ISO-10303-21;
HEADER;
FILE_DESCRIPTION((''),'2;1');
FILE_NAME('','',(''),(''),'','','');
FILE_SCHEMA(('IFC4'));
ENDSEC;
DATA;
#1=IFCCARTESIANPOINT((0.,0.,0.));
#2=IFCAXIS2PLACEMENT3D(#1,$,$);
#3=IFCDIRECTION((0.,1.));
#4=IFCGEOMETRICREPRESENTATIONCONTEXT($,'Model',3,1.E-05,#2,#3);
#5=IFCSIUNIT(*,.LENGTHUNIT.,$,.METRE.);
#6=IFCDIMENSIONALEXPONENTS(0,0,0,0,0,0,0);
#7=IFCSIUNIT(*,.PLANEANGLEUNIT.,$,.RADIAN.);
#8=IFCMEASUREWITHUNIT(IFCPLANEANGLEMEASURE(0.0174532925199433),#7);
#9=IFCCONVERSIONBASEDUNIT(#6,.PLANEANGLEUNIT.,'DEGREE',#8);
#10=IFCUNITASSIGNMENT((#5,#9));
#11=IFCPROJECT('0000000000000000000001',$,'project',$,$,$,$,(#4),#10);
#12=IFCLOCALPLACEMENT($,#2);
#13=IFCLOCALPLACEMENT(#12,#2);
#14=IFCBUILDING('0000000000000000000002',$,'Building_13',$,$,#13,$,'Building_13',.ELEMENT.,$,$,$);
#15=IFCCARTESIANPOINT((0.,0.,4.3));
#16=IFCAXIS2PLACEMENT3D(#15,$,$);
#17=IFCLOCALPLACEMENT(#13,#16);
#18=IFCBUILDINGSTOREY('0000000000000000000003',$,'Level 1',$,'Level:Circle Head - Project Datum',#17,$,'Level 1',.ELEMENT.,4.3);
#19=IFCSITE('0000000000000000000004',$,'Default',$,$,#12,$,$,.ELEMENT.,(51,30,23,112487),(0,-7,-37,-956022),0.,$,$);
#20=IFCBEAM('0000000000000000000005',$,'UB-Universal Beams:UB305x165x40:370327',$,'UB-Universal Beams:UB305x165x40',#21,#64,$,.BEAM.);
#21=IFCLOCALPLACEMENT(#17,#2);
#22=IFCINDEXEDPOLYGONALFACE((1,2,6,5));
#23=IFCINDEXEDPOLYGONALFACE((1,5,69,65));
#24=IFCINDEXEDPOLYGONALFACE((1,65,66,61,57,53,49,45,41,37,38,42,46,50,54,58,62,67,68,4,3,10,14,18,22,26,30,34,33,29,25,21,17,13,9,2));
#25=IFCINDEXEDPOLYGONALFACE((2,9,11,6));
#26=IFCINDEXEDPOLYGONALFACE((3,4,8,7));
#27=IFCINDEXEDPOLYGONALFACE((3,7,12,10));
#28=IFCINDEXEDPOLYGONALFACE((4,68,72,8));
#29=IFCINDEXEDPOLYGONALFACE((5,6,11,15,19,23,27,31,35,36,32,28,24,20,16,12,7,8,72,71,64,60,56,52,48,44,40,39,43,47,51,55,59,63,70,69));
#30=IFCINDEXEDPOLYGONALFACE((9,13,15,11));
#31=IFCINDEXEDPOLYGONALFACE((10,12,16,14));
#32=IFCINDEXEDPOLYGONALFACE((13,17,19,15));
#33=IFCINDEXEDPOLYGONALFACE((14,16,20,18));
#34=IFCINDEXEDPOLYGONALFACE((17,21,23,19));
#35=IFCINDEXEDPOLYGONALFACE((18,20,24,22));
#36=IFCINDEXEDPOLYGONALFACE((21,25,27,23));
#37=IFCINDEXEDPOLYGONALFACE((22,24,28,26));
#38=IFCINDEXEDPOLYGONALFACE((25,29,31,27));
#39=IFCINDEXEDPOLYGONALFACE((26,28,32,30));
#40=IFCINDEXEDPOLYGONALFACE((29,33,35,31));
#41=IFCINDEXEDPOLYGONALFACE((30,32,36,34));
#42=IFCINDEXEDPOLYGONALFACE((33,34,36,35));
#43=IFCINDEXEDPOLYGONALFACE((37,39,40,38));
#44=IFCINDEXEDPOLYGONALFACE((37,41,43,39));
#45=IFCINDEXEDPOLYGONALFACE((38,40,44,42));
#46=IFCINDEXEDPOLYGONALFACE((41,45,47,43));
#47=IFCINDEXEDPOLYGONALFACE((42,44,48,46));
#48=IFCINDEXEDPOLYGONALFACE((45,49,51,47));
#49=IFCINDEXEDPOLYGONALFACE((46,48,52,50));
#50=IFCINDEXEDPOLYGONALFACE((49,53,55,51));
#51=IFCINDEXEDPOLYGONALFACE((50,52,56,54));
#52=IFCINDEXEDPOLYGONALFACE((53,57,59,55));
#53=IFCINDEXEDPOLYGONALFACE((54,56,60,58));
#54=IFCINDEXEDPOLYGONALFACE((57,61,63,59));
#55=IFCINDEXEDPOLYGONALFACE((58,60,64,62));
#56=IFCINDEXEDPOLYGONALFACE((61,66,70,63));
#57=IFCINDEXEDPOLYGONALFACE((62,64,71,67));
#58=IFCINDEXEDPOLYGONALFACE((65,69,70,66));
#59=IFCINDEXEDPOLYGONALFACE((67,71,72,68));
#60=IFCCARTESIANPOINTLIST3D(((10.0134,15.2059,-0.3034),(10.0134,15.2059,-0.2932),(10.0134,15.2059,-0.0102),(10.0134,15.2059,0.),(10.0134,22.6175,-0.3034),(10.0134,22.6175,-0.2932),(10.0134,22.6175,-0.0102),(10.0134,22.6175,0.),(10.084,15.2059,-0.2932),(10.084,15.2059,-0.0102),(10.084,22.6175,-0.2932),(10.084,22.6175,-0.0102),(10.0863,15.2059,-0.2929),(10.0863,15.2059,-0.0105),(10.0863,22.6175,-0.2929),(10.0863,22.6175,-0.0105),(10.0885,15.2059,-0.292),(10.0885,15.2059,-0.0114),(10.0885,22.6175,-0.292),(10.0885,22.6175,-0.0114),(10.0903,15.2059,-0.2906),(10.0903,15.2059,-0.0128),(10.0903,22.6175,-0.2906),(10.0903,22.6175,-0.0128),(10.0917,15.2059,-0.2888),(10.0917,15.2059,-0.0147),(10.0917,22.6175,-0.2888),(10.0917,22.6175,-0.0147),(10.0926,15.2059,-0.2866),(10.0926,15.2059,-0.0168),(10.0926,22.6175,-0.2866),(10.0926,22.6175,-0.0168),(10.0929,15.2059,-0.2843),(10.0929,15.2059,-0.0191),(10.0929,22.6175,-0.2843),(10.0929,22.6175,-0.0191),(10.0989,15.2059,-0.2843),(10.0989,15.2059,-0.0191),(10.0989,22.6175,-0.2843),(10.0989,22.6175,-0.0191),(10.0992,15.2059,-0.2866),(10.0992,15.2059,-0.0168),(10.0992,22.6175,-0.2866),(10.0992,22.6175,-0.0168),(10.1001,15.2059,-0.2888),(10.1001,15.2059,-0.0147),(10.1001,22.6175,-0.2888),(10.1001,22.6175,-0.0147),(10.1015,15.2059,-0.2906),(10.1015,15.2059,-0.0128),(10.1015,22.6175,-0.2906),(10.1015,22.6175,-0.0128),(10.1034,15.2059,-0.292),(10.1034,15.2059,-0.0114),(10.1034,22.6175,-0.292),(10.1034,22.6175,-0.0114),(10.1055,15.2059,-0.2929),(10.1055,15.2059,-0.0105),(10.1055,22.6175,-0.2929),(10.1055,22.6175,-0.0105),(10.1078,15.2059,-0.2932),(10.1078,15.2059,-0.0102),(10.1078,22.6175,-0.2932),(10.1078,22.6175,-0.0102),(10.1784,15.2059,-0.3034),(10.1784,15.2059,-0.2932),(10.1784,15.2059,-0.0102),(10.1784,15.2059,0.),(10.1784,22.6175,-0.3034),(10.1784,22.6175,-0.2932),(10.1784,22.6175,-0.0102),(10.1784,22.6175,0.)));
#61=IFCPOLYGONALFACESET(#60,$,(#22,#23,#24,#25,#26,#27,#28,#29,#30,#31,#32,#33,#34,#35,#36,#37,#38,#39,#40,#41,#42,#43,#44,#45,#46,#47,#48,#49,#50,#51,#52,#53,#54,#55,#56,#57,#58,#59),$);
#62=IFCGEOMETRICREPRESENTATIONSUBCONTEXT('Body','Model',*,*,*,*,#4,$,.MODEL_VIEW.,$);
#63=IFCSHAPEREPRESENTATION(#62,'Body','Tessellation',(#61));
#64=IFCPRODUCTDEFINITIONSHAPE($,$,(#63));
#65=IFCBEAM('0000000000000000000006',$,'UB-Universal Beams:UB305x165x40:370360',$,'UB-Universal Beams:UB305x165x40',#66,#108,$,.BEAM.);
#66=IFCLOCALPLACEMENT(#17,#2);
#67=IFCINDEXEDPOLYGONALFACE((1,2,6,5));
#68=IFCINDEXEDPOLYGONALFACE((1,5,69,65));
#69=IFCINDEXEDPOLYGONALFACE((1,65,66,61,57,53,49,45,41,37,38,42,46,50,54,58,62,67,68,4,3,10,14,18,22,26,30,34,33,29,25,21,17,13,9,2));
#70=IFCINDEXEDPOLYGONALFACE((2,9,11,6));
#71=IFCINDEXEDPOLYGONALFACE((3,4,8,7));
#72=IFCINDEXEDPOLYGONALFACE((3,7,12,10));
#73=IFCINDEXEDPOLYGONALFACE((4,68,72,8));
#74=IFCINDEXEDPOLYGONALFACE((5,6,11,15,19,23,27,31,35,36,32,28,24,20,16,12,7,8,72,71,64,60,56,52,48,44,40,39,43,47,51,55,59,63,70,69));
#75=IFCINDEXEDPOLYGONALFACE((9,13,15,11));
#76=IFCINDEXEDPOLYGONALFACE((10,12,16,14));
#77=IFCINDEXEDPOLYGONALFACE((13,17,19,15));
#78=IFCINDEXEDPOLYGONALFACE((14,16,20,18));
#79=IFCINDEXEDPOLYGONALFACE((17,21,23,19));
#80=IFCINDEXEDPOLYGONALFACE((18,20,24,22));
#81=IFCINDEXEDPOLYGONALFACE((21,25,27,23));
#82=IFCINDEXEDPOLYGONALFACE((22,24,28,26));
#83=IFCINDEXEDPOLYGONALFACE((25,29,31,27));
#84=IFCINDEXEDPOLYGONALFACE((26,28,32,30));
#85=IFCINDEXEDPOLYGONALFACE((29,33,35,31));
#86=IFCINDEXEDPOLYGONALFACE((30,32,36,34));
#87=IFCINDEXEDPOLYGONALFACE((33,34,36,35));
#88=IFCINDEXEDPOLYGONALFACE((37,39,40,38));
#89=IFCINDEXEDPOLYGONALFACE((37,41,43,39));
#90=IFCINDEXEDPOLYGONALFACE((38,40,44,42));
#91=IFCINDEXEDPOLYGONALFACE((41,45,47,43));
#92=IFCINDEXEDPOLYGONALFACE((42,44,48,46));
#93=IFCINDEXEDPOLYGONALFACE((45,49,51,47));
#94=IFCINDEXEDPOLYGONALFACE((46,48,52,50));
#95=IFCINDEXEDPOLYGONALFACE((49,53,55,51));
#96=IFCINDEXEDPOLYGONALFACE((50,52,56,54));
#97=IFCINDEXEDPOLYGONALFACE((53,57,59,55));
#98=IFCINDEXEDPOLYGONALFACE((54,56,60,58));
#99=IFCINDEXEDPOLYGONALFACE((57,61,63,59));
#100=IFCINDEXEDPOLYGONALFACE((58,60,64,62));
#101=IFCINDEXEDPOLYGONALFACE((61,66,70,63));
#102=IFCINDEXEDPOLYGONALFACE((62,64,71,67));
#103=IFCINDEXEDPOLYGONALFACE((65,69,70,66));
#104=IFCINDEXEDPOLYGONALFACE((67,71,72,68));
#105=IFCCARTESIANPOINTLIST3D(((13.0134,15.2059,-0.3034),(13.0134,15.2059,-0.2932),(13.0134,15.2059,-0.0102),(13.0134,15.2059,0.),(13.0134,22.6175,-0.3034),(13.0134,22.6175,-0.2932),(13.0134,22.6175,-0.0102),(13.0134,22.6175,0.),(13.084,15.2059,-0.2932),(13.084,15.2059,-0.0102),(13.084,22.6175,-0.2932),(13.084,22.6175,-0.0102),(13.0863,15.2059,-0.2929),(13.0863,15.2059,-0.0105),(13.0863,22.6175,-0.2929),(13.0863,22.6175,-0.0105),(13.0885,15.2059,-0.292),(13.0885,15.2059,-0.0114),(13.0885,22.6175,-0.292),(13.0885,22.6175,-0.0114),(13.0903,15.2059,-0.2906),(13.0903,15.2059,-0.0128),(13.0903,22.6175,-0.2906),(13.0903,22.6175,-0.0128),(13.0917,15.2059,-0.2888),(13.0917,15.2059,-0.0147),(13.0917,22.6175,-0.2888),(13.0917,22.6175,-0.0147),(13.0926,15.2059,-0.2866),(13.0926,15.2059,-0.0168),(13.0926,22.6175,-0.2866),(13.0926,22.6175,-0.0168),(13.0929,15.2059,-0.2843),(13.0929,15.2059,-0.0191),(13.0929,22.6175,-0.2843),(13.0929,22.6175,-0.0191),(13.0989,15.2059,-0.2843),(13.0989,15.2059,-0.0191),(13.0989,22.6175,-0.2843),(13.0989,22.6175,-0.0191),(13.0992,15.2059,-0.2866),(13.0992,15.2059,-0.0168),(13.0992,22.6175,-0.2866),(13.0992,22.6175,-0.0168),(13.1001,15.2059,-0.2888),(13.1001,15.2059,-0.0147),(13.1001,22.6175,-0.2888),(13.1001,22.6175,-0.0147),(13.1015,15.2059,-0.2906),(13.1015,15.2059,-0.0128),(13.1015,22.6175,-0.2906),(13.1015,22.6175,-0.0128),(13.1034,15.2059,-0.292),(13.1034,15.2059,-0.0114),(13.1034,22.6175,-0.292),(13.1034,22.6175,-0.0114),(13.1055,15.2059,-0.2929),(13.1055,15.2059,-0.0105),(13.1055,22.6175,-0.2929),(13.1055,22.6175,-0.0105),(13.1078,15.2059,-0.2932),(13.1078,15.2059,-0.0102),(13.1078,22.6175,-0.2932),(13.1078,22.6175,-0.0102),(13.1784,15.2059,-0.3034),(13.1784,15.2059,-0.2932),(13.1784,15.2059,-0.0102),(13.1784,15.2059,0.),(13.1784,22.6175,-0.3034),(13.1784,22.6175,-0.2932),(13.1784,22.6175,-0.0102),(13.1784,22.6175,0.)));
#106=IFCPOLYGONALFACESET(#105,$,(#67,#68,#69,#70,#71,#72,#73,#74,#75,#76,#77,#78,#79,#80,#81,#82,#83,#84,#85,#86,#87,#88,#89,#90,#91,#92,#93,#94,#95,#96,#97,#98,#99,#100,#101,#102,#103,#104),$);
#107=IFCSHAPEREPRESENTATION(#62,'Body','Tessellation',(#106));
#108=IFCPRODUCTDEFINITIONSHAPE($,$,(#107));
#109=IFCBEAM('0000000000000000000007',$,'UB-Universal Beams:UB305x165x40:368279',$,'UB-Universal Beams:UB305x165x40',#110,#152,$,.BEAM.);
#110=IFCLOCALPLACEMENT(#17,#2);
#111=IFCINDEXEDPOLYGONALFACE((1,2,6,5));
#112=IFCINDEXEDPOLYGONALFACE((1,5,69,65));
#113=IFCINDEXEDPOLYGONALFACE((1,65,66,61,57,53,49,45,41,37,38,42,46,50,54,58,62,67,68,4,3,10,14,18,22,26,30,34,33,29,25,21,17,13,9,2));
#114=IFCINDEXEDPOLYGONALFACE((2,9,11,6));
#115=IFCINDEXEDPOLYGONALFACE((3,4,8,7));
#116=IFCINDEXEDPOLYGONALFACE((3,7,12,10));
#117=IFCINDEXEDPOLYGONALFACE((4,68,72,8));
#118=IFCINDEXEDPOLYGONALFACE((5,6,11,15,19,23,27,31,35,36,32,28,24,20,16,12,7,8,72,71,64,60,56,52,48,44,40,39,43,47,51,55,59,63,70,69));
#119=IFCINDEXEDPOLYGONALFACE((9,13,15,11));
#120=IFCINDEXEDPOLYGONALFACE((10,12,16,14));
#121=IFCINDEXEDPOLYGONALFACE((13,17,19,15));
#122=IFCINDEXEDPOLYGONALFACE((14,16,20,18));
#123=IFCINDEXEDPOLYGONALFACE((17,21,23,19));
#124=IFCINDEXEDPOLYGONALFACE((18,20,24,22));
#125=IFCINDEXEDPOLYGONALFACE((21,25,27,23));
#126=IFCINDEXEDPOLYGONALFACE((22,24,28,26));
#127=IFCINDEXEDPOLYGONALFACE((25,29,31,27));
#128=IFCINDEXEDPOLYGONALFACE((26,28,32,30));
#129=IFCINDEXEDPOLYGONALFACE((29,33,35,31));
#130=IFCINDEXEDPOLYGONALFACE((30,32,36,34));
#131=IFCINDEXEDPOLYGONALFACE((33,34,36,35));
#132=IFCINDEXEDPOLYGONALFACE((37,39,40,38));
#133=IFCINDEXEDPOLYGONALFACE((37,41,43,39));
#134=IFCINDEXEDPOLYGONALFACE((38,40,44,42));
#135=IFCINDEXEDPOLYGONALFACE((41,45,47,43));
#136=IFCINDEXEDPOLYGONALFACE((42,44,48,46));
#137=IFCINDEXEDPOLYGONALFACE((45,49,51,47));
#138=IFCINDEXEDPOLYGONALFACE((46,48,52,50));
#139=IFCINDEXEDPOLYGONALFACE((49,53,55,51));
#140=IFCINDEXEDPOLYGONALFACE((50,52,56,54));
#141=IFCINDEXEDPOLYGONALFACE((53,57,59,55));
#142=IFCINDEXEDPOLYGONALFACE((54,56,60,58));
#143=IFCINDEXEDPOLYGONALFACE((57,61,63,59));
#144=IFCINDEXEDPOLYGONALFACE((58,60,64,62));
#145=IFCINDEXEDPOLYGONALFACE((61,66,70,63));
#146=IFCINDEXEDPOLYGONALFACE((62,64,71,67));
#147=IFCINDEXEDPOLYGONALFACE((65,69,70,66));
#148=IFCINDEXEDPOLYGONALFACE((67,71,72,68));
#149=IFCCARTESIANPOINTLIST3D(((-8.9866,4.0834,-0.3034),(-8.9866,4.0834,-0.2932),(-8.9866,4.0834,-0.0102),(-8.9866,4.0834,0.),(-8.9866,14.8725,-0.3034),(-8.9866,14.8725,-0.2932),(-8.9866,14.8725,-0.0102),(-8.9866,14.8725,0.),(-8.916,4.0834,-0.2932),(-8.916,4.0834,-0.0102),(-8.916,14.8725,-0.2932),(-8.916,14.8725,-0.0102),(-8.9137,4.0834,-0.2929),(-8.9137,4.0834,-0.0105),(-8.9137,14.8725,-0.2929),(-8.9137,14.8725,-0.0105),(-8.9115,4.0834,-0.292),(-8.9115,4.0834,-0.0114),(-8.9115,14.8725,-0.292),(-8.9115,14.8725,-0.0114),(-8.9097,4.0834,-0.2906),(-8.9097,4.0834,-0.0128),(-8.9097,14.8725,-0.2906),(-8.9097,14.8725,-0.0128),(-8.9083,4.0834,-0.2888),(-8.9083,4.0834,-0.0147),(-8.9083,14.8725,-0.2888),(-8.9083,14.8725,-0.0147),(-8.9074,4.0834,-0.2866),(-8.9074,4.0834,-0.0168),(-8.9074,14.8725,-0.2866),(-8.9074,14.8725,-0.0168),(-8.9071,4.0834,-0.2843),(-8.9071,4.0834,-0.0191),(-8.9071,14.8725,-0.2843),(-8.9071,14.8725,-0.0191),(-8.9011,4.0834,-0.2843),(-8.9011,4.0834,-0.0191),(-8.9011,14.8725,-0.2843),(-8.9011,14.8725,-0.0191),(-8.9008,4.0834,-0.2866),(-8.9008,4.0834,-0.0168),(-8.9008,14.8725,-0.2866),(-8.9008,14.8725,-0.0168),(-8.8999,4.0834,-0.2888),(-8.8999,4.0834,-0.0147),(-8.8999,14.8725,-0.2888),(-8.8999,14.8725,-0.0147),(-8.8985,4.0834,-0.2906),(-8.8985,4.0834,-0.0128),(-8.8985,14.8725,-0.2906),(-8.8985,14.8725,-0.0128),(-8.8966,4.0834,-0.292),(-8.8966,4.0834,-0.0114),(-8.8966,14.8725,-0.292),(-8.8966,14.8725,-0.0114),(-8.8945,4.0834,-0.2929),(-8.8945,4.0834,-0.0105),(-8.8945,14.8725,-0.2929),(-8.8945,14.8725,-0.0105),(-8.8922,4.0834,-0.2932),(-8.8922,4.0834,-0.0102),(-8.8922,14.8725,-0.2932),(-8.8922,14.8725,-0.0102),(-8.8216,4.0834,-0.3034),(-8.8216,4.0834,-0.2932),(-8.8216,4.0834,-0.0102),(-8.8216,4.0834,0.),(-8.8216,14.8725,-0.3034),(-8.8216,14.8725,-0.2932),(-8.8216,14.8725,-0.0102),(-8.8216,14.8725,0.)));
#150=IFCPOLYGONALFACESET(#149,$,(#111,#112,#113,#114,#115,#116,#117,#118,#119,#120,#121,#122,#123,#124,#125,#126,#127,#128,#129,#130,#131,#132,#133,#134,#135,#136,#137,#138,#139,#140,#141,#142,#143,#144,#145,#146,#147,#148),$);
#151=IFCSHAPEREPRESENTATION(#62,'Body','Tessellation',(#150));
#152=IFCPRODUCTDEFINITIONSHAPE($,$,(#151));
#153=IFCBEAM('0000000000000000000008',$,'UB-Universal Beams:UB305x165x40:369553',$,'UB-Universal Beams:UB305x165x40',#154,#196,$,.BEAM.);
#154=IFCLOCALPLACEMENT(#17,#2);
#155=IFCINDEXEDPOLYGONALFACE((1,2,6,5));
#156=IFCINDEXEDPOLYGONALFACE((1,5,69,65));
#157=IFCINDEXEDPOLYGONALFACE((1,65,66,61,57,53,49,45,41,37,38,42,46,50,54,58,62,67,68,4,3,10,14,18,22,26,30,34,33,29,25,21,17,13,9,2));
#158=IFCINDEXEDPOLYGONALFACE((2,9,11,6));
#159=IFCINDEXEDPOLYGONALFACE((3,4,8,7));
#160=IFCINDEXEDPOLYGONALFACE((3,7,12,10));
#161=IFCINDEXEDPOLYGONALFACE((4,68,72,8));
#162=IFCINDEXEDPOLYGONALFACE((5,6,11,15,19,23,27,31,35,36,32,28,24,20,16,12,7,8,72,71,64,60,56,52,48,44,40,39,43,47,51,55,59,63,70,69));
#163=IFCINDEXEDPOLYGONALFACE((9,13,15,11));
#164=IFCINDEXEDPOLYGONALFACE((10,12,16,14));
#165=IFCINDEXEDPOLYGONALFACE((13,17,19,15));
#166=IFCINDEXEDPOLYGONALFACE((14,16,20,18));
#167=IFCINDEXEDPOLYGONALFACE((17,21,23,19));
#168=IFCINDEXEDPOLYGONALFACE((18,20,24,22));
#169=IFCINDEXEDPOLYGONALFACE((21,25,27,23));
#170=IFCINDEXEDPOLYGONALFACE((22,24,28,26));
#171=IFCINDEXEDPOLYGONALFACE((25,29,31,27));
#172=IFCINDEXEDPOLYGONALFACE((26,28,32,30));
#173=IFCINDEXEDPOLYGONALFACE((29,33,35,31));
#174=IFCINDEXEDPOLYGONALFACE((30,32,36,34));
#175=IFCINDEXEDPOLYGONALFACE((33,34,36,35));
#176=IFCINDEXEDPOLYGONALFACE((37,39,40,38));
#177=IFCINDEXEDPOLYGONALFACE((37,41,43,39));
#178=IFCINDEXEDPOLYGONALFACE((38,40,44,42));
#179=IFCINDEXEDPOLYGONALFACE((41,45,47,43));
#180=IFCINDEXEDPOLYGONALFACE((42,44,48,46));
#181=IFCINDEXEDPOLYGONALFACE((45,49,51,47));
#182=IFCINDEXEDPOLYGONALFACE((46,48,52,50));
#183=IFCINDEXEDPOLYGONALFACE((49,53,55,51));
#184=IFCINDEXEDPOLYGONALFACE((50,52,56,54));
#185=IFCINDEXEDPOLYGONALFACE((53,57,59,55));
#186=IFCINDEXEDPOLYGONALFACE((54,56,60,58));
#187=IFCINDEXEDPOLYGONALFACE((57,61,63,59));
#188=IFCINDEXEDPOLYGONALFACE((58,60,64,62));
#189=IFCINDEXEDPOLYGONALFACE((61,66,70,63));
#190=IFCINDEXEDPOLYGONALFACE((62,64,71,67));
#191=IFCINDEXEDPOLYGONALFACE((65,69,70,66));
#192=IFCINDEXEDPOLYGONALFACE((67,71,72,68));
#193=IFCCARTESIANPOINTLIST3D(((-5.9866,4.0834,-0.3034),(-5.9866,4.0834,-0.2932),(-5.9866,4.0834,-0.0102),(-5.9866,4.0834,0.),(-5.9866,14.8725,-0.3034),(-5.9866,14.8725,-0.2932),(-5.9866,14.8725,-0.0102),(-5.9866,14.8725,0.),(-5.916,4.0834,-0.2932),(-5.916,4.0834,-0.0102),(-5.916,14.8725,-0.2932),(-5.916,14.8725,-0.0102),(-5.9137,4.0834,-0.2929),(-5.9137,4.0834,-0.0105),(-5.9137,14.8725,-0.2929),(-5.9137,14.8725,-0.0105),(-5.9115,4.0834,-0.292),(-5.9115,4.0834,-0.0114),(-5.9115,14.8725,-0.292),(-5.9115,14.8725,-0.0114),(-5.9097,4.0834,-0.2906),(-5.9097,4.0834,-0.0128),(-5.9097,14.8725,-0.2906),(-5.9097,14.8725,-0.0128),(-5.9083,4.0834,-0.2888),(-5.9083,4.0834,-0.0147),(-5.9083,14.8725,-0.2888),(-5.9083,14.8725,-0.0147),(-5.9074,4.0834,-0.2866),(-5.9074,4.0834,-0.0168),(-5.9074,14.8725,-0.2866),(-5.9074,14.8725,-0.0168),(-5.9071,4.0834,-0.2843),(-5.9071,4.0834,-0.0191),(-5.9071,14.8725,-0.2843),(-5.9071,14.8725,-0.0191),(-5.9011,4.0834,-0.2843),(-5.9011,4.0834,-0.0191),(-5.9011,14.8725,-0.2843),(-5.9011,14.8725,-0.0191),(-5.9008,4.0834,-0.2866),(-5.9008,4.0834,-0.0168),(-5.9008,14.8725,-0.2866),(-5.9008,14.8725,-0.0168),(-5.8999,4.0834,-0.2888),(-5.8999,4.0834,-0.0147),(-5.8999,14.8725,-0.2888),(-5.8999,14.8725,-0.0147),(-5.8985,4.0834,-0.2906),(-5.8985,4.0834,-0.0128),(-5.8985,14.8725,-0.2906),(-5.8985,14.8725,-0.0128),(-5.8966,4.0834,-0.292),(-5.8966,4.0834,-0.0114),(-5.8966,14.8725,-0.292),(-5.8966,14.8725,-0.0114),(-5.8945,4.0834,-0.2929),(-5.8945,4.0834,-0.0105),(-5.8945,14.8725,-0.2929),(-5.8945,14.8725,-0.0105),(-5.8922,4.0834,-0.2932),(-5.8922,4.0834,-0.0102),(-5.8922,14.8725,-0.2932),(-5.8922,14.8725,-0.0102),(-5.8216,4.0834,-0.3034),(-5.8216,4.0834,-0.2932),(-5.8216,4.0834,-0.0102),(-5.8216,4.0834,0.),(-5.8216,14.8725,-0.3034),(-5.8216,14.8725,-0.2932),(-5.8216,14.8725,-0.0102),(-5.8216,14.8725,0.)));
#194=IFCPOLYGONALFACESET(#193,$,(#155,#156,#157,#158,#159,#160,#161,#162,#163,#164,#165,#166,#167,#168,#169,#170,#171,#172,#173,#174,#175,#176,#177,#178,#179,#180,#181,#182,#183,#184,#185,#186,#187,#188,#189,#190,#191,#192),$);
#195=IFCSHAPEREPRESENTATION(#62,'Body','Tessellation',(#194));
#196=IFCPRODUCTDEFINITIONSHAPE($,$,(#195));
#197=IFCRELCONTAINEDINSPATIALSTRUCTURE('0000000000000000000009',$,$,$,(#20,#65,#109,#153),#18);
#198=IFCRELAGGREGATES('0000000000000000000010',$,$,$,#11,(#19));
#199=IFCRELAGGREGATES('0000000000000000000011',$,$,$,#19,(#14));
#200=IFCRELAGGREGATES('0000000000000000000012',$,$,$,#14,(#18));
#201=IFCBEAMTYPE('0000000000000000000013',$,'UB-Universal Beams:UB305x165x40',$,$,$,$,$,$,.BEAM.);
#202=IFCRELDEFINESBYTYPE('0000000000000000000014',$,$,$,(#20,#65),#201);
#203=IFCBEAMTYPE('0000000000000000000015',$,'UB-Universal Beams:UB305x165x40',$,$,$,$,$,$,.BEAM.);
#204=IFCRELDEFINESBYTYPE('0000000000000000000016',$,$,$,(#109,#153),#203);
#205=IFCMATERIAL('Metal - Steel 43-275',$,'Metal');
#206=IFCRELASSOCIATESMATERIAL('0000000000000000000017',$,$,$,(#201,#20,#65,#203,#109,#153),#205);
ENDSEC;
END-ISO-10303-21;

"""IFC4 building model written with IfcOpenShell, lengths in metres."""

from ifc_helpers import new_model, entity, si_unit, converted_unit, direction, frame, origin, place, context, subcontext, project, spatial, line, arc, indexed_curve, outline, extrude, source, transform, mapped, material, type_object, type_shapes, element, save


model = new_model("IFC4")

# Units and contexts
model_context = context("Model", 3, precision=1e-05, world=origin(), true_north=direction((0.0, 1.0)))
body_context = subcontext(model_context, "Body", "Model", "MODEL_VIEW")
ifc_project = project(units=[si_unit("LENGTHUNIT", "METRE"), converted_unit("PLANEANGLEUNIT", "DEGREE", entity("IfcPlaneAngleMeasure", 0.0174532925199433), si_unit("PLANEANGLEUNIT", "RADIAN"), dimensions=[0, 0, 0, 0, 0, 0, 0])], contexts=[model_context])

# Site, building, storey
site_placement = place(None, origin())
site = spatial("IfcSite", under=ifc_project, at=site_placement, Name="Default", CompositionType="ELEMENT", RefLatitude=(51, 30, 23, 112487), RefLongitude=(0, -7, -37, -956022), RefElevation=0.0)
building_placement = place(site_placement, origin())
building = spatial("IfcBuilding", under=site, at=building_placement, Name="Building_13", LongName="Building_13", CompositionType="ELEMENT")
storey_placement = place(building_placement, frame((0.0, 0.0, 4.3)))
storey = spatial("IfcBuildingStorey", under=building, at=storey_placement, Name="Level 1", ObjectType="Level:Circle Head - Project Datum", LongName="Level 1", CompositionType="ELEMENT", Elevation=4.3)

# Beams
ifc_material_1 = material(Name="Metal - Steel 43-275", Category="Metal")
beam_type_1 = type_object("IfcBeamType", Name="UB-Universal Beams:UB305x165x40", PredefinedType="BEAM", material=ifc_material_1)
shared_shape_1 = source(origin(), body_context, "Body", "SweptSolid", [
    extrude(outline(indexed_curve([(-0.0825, -0.1415), (-0.0825, -0.1517), (0.0825, -0.1517), (0.0825, -0.1415), (0.0119, -0.1415), (0.0056, -0.1389), (0.003, -0.1326), (0.003, 0.1326), (0.0056, 0.1389), (0.0119, 0.1415), (0.0825, 0.1415), (0.0825, 0.1517), (-0.0825, 0.1517), (-0.0825, 0.1415), (-0.0119, 0.1415), (-0.0056, 0.1389), (-0.003, 0.1326), (-0.003, -0.1326), (-0.0056, -0.1389), (-0.0119, -0.1415)], segments=[line(1, 2, 3, 4, 5), arc(5, 6, 7), line(7, 8), arc(8, 9, 10), line(10, 11, 12, 13, 14, 15), arc(15, 16, 17), line(17, 18), arc(18, 19, 20), line(20, 1)], self_intersect=False)), frame((-3.7058, 0.0, 0.0), z_axis=(-1.0, 0.0, 0.0), x_axis=(0.0, -1.0, 0.0)), (0.0, 0.0, -1.0), 7.4116),
])
type_shapes(beam_type_1, [shared_shape_1])
for number, where, z_axis, x_axis, name in (
    (1, (10.0959, 18.9117, -0.1517), (0.0, 0.0, 1.0), (0.0, -1.0, 0.0), "UB-Universal Beams:UB305x165x40:370327"),
    (2, (13.0959, 18.9117, -0.1517), (0.0, 0.0, 1.0), (0.0, -1.0, 0.0), "UB-Universal Beams:UB305x165x40:370360"),
):
    element("IfcBeam", number, at=place(storey_placement, frame(where, z_axis=z_axis, x_axis=x_axis)), inside=storey, type_object=beam_type_1, material=ifc_material_1, Name=name, ObjectType="UB-Universal Beams:UB305x165x40", PredefinedType="BEAM", context=body_context, shape_type="MappedRepresentation", body=[
        mapped(shared_shape_1, transform((0.0, 0.0, 0.0), scale=1.0)),
    ])
beam_type_2 = type_object("IfcBeamType", Name="UB-Universal Beams:UB305x165x40", PredefinedType="BEAM", material=ifc_material_1)
shared_shape_2 = source(origin(), body_context, "Body", "SweptSolid", [
    extrude(outline(indexed_curve([(-0.0825, -0.1415), (-0.0825, -0.1517), (0.0825, -0.1517), (0.0825, -0.1415), (0.0119, -0.1415), (0.0056, -0.1389), (0.003, -0.1326), (0.003, 0.1326), (0.0056, 0.1389), (0.0119, 0.1415), (0.0825, 0.1415), (0.0825, 0.1517), (-0.0825, 0.1517), (-0.0825, 0.1415), (-0.0119, 0.1415), (-0.0056, 0.1389), (-0.003, 0.1326), (-0.003, -0.1326), (-0.0056, -0.1389), (-0.0119, -0.1415)], segments=[line(1, 2, 3, 4, 5), arc(5, 6, 7), line(7, 8), arc(8, 9, 10), line(10, 11, 12, 13, 14, 15), arc(15, 16, 17), line(17, 18), arc(18, 19, 20), line(20, 1)], self_intersect=False)), frame((-5.3945, 0.0, 0.0), z_axis=(-1.0, 0.0, 0.0), x_axis=(0.0, -1.0, 0.0)), (0.0, 0.0, -1.0), 10.7891),
])
type_shapes(beam_type_2, [shared_shape_2])
for number, where, z_axis, x_axis, name in (
    (3, (-8.9041, 9.4779, -0.1517), (0.0, 0.0, 1.0), (0.0, -1.0, 0.0), "UB-Universal Beams:UB305x165x40:368279"),
    (4, (-5.9041, 9.4779, -0.1517), (0.0, 0.0, 1.0), (0.0, -1.0, 0.0), "UB-Universal Beams:UB305x165x40:369553"),
):
    element("IfcBeam", number, at=place(storey_placement, frame(where, z_axis=z_axis, x_axis=x_axis)), inside=storey, type_object=beam_type_2, material=ifc_material_1, Name=name, ObjectType="UB-Universal Beams:UB305x165x40", PredefinedType="BEAM", context=body_context, shape_type="MappedRepresentation", body=[
        mapped(shared_shape_2, transform((0.0, 0.0, 0.0), scale=1.0)),
    ])

save(model, "model.ifc")
